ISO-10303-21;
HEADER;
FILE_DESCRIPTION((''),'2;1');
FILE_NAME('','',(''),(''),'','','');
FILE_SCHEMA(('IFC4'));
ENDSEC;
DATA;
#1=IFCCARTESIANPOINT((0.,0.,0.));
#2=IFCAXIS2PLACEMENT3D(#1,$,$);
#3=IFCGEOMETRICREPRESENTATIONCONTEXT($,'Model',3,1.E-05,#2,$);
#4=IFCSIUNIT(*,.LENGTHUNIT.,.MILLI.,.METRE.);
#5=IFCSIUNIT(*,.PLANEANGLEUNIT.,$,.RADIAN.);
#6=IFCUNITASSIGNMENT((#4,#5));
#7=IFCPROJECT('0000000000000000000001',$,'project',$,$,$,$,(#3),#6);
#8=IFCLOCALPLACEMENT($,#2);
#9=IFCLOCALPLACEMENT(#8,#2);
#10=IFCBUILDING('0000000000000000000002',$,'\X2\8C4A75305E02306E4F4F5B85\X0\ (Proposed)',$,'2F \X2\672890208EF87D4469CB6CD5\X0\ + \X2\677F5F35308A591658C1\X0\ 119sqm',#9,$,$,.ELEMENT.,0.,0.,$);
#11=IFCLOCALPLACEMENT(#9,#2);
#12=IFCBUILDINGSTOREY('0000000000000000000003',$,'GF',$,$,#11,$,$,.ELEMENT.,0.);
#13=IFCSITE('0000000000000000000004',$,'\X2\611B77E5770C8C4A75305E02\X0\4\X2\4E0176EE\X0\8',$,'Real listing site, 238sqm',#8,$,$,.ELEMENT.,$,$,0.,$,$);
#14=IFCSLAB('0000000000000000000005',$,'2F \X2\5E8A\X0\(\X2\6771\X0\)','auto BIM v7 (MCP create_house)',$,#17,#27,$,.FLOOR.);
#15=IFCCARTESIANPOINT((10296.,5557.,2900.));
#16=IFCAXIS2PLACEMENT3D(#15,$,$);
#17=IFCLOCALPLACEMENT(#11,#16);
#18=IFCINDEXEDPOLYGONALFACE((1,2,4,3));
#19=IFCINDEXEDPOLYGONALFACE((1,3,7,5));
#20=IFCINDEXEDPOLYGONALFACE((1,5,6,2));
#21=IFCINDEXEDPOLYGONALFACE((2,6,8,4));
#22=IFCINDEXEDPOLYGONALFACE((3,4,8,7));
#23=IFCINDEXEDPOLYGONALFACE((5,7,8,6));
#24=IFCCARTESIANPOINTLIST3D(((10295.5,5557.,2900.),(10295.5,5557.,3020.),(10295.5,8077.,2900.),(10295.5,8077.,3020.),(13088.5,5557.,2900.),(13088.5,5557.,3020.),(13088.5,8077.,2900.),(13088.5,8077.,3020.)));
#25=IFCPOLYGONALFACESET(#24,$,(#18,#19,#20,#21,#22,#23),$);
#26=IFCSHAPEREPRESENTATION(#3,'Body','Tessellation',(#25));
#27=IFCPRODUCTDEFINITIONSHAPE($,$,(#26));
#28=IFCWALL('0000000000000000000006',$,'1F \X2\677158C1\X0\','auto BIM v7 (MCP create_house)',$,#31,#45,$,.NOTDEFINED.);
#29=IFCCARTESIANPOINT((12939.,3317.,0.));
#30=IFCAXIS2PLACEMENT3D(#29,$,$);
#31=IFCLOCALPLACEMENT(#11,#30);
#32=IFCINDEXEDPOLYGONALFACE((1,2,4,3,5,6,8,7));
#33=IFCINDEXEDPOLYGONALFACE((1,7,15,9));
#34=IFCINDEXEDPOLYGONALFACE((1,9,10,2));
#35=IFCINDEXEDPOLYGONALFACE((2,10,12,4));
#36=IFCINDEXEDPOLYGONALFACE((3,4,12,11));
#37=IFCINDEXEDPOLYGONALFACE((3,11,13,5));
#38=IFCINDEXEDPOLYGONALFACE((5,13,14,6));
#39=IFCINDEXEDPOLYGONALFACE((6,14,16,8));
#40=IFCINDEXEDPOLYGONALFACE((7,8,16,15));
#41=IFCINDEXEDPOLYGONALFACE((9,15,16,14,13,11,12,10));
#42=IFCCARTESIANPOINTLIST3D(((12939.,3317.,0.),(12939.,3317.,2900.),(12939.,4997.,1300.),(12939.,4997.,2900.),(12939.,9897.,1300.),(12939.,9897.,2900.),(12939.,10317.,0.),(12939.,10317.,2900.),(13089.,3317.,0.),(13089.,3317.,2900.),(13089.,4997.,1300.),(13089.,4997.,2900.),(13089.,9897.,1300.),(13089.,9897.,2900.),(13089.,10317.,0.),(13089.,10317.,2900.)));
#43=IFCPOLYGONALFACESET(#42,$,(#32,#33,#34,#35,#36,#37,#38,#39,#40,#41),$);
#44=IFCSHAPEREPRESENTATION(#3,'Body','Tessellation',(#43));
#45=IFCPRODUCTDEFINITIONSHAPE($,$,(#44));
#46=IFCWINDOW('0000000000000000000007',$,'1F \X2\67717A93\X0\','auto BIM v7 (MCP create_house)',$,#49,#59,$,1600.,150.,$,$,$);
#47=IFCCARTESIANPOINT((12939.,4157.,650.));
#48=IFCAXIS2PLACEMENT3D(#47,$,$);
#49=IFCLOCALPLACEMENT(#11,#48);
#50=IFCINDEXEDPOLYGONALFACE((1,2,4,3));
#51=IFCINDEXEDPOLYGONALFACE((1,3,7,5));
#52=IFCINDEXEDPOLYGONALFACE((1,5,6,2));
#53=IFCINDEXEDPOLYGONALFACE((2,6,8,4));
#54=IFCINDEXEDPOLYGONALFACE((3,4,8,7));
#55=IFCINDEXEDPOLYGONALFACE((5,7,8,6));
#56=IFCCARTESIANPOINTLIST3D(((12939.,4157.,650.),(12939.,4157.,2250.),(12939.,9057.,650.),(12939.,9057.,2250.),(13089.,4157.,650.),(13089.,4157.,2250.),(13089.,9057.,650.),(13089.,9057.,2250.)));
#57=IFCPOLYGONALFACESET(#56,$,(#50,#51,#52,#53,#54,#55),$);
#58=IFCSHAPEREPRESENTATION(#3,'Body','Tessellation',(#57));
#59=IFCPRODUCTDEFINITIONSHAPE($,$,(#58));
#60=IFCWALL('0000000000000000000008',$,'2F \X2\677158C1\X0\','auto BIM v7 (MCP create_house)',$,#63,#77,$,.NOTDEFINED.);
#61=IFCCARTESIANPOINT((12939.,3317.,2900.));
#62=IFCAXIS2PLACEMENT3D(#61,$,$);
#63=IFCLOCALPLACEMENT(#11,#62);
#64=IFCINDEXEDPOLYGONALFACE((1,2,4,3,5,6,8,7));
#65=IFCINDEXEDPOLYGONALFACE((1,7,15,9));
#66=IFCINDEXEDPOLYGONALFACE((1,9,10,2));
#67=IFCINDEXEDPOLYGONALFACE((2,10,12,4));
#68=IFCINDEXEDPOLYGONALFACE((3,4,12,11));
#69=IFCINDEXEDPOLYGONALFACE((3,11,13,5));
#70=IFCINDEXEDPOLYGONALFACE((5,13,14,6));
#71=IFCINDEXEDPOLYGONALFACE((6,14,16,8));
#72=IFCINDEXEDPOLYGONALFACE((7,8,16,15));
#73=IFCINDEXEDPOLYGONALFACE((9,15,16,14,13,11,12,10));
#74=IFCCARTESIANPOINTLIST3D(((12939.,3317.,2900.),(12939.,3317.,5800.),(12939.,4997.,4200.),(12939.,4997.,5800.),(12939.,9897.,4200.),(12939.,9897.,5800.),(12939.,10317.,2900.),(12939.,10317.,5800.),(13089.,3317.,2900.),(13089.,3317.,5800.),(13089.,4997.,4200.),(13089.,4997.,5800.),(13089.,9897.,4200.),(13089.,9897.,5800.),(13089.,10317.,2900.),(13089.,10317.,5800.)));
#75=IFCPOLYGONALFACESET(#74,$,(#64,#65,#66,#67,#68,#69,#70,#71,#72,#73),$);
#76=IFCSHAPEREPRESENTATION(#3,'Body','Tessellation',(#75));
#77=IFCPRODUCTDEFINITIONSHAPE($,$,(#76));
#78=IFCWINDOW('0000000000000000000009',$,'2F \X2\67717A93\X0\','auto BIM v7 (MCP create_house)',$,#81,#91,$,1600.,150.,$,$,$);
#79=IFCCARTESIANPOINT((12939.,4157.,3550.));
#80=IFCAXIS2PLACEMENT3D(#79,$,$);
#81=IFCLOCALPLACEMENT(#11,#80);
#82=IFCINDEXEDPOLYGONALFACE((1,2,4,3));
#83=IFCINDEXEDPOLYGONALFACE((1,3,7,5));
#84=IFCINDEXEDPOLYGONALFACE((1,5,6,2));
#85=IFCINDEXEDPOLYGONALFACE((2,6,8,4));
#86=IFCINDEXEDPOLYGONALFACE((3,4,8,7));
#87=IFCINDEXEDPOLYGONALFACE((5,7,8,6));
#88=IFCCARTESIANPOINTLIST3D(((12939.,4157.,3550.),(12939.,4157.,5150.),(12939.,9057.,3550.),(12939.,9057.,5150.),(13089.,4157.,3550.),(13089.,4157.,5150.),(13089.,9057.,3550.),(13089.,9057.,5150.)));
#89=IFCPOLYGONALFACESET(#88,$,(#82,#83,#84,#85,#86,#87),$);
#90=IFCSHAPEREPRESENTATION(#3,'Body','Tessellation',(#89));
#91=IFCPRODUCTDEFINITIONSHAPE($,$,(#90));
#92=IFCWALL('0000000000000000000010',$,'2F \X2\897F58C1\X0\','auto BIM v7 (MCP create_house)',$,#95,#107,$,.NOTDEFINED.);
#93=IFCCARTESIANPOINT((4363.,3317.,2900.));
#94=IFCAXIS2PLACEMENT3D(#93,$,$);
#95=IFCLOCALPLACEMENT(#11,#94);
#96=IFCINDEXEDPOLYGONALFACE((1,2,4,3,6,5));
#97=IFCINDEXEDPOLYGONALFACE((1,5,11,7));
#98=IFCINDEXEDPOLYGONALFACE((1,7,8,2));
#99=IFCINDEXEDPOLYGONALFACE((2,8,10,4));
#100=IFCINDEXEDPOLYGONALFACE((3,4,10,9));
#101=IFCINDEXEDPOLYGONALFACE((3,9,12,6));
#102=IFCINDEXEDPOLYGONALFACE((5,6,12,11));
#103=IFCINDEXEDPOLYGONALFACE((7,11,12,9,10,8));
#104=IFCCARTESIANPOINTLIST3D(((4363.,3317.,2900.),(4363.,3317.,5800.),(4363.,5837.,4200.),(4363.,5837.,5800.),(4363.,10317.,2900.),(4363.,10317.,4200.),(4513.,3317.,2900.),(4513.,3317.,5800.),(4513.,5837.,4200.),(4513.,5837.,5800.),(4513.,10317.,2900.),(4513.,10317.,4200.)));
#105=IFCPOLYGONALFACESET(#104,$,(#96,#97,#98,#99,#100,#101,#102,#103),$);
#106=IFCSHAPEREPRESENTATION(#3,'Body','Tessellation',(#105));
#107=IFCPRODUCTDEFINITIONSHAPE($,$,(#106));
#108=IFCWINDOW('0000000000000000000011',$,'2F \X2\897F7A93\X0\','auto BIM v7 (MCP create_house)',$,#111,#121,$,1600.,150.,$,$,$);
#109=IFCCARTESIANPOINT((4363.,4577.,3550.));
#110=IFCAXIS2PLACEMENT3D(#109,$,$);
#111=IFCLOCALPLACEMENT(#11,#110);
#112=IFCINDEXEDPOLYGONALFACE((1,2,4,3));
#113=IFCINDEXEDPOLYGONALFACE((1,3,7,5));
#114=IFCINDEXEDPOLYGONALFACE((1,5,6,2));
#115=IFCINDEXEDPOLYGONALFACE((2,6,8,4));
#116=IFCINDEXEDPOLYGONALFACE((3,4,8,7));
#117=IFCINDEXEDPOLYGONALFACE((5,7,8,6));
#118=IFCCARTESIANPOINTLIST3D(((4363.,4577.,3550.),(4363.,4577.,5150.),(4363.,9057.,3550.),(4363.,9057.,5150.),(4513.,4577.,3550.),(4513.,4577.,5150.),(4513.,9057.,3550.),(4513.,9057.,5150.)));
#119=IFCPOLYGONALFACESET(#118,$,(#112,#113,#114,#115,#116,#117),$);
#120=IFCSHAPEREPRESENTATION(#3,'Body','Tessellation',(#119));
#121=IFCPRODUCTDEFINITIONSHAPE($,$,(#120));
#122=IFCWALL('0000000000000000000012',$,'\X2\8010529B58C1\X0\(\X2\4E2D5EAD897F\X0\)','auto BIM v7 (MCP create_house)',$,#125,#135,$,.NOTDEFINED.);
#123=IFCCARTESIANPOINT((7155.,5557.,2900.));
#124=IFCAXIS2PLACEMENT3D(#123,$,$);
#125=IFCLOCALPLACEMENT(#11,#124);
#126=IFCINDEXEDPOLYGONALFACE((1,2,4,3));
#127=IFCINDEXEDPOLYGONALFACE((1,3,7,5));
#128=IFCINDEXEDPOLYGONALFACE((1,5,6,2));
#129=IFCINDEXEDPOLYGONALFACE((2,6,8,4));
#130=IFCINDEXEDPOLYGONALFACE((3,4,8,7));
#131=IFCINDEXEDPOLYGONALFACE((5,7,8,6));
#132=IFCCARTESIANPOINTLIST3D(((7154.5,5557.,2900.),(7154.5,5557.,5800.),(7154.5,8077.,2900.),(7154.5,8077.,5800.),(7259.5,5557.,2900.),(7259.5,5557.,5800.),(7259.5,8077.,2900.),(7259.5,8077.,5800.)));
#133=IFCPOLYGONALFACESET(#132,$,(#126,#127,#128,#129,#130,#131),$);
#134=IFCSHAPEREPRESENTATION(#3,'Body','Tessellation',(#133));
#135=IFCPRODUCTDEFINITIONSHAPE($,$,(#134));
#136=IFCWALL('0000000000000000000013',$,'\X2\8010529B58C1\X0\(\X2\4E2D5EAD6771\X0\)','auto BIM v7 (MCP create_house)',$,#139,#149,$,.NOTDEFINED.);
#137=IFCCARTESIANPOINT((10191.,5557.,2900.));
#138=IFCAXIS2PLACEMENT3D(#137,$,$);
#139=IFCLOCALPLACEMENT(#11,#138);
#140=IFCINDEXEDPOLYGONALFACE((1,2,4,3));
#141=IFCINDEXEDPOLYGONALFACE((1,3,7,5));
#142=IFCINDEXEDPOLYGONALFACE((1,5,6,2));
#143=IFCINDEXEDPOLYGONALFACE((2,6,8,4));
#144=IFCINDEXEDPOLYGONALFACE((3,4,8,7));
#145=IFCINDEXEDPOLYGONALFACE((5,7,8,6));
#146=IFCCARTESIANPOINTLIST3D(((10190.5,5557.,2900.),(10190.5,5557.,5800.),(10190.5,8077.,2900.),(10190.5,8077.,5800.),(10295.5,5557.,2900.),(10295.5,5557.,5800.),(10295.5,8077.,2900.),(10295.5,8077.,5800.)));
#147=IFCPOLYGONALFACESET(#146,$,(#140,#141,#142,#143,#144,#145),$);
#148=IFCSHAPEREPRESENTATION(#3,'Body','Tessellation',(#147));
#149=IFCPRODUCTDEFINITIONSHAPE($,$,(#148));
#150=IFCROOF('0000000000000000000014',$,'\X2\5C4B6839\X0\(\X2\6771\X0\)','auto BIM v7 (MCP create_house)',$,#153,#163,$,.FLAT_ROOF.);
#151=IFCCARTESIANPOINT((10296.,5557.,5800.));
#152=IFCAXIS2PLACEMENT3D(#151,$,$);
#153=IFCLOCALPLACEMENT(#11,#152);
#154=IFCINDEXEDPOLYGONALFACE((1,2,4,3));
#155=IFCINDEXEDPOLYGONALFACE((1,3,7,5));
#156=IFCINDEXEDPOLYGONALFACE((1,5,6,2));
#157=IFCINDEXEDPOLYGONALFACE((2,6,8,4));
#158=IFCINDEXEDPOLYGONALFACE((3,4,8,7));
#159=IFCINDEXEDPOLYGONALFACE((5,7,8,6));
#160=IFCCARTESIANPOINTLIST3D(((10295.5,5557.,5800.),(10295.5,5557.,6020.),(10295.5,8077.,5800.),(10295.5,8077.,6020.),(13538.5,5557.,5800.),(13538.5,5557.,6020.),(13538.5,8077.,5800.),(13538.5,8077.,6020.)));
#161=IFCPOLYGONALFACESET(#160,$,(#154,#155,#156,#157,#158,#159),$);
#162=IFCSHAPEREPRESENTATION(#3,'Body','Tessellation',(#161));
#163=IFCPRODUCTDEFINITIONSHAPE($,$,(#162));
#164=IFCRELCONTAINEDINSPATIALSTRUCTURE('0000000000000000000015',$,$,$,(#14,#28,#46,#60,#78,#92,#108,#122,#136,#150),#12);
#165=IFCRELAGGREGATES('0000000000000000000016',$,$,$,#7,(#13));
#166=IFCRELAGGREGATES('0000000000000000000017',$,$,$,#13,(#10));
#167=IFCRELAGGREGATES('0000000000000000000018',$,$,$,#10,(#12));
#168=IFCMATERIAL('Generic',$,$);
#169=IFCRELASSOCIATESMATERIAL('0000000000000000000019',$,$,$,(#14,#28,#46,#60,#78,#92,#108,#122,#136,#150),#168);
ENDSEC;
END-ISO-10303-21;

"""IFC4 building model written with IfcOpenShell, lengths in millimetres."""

from ifc_helpers import new_model, si_unit, frame, frame_2d, origin, place, context, project, spatial, rectangle, extrude, material, element, fill, save


model = new_model("IFC4")

# Units and contexts
model_context = context("Model", 3, precision=1e-05, world=origin())
ifc_project = project(units=[si_unit("LENGTHUNIT", "METRE", prefix="MILLI"), si_unit("PLANEANGLEUNIT", "RADIAN")], contexts=[model_context])

# Site, building, storey
site_placement = place(None, origin())
site = spatial("IfcSite", under=ifc_project, at=site_placement, Name="愛知県豊田市4丁目8", ObjectType="Real listing site, 238sqm", CompositionType="ELEMENT", RefElevation=0.0)
building_placement = place(site_placement, origin())
building = spatial("IfcBuilding", under=site, at=building_placement, Name="豊田市の住宅 (Proposed)", ObjectType="2F 木造軸組構法 + 板張り外壁 119sqm", CompositionType="ELEMENT", ElevationOfRefHeight=0.0, ElevationOfTerrain=0.0)
storey_placement = place(building_placement, origin())
storey = spatial("IfcBuildingStorey", under=building, at=storey_placement, Name="GF", CompositionType="ELEMENT", Elevation=0.0)

# Slab
ifc_material = material(Name="Generic")
slab_1_placement = place(storey_placement, frame((10296.0, 5557.0, 2900.0)))
element("IfcSlab", 1, at=slab_1_placement, inside=storey, material=ifc_material, Name="2F 床(東)", Description="auto BIM v7 (MCP create_house)", PredefinedType="FLOOR", context=model_context, shape_type="SweptSolid", body=[
    extrude(rectangle(XDim=2793.0, YDim=2520.0, at=frame_2d((1396.0, 1260.0))), frame((10296.0, 5557.0, 2900.0)), (0.0, 0.0, 1.0), 120.0),
])

# Wall, opening, window
wall_1_placement = place(storey_placement, frame((12939.0, 3317.0, 0.0)))
wall_1 = element("IfcWall", 2, at=wall_1_placement, inside=storey, material=ifc_material, Name="1F 東壁", Description="auto BIM v7 (MCP create_house)", PredefinedType="NOTDEFINED", context=model_context, shape_type="SweptSolid", body=[
    extrude(rectangle(XDim=150.0, YDim=7000.0, at=frame_2d((75.0, 3500.0))), frame((12939.0, 3317.0, 0.0)), (0.0, 0.0, 1.0), 2900.0),
])
opening_1_placement = place(storey_placement, frame((12939.0, 4157.0, 650.0)))
opening_1 = element("IfcOpeningElement", 3, at=opening_1_placement, cuts=wall_1, PredefinedType="NOTDEFINED", context=model_context, shape_type="SweptSolid", body=[
    extrude(rectangle(XDim=150.0, YDim=4900.0, at=frame_2d((75.0, 2450.0))), frame((12939.0, 4157.0, 650.0)), (0.0, 0.0, 1.0), 1600.0),
])
window_1_placement = place(storey_placement, frame((12939.0, 4157.0, 650.0)))
window_1 = element("IfcWindow", 4, at=window_1_placement, inside=storey, material=ifc_material, Name="1F 東窓", Description="auto BIM v7 (MCP create_house)", OverallHeight=1600.0, OverallWidth=150.0, context=model_context, shape_type="SweptSolid", body=[
    extrude(rectangle(XDim=150.0, YDim=4900.0, at=frame_2d((75.0, 2450.0))), frame((12939.0, 4157.0, 650.0)), (0.0, 0.0, 1.0), 1600.0),
])
fill(opening_1, window_1)

# Walls, openings, windows
wall_2_placement = place(storey_placement, frame((12939.0, 3317.0, 2900.0)))
wall_2 = element("IfcWall", 5, at=wall_2_placement, inside=storey, material=ifc_material, Name="2F 東壁", Description="auto BIM v7 (MCP create_house)", PredefinedType="NOTDEFINED", context=model_context, shape_type="SweptSolid", body=[
    extrude(rectangle(XDim=150.0, YDim=7000.0, at=frame_2d((75.0, 3500.0))), frame((12939.0, 3317.0, 2900.0)), (0.0, 0.0, 1.0), 2900.0),
])
opening_2_placement = place(storey_placement, frame((12939.0, 4157.0, 3550.0)))
opening_2 = element("IfcOpeningElement", 6, at=opening_2_placement, cuts=wall_2, PredefinedType="NOTDEFINED", context=model_context, shape_type="SweptSolid", body=[
    extrude(rectangle(XDim=150.0, YDim=4900.0, at=frame_2d((75.0, 2450.0))), frame((12939.0, 4157.0, 3550.0)), (0.0, 0.0, 1.0), 1600.0),
])
window_2_placement = place(storey_placement, frame((12939.0, 4157.0, 3550.0)))
window_2 = element("IfcWindow", 7, at=window_2_placement, inside=storey, material=ifc_material, Name="2F 東窓", Description="auto BIM v7 (MCP create_house)", OverallHeight=1600.0, OverallWidth=150.0, context=model_context, shape_type="SweptSolid", body=[
    extrude(rectangle(XDim=150.0, YDim=4900.0, at=frame_2d((75.0, 2450.0))), frame((12939.0, 4157.0, 3550.0)), (0.0, 0.0, 1.0), 1600.0),
])
fill(opening_2, window_2)
wall_3_placement = place(storey_placement, frame((4363.0, 3317.0, 2900.0)))
wall_3 = element("IfcWall", 8, at=wall_3_placement, inside=storey, material=ifc_material, Name="2F 西壁", Description="auto BIM v7 (MCP create_house)", PredefinedType="NOTDEFINED", context=model_context, shape_type="SweptSolid", body=[
    extrude(rectangle(XDim=150.0, YDim=7000.0, at=frame_2d((75.0, 3500.0))), frame((4363.0, 3317.0, 2900.0)), (0.0, 0.0, 1.0), 2900.0),
])
opening_3_placement = place(storey_placement, frame((4363.0, 4577.0, 3550.0)))
opening_3 = element("IfcOpeningElement", 9, at=opening_3_placement, cuts=wall_3, PredefinedType="NOTDEFINED", context=model_context, shape_type="SweptSolid", body=[
    extrude(rectangle(XDim=150.0, YDim=4480.0, at=frame_2d((75.0, 2240.0))), frame((4363.0, 4577.0, 3550.0)), (0.0, 0.0, 1.0), 1600.0),
])
window_3_placement = place(storey_placement, frame((4363.0, 4577.0, 3550.0)))
window_3 = element("IfcWindow", 10, at=window_3_placement, inside=storey, material=ifc_material, Name="2F 西窓", Description="auto BIM v7 (MCP create_house)", OverallHeight=1600.0, OverallWidth=150.0, context=model_context, shape_type="SweptSolid", body=[
    extrude(rectangle(XDim=150.0, YDim=4480.0, at=frame_2d((75.0, 2240.0))), frame((4363.0, 4577.0, 3550.0)), (0.0, 0.0, 1.0), 1600.0),
])
fill(opening_3, window_3)

# Walls
wall_4_placement = place(storey_placement, frame((7155.0, 5557.0, 2900.0)))
element("IfcWall", 11, at=wall_4_placement, inside=storey, material=ifc_material, Name="耐力壁(中庭西)", Description="auto BIM v7 (MCP create_house)", PredefinedType="NOTDEFINED", context=model_context, shape_type="SweptSolid", body=[
    extrude(rectangle(XDim=105.0, YDim=2520.0, at=frame_2d((52.0, 1260.0))), frame((7155.0, 5557.0, 2900.0)), (0.0, 0.0, 1.0), 2900.0),
])
wall_5_placement = place(storey_placement, frame((10191.0, 5557.0, 2900.0)))
element("IfcWall", 12, at=wall_5_placement, inside=storey, material=ifc_material, Name="耐力壁(中庭東)", Description="auto BIM v7 (MCP create_house)", PredefinedType="NOTDEFINED", context=model_context, shape_type="SweptSolid", body=[
    extrude(rectangle(XDim=105.0, YDim=2520.0, at=frame_2d((52.0, 1260.0))), frame((10191.0, 5557.0, 2900.0)), (0.0, 0.0, 1.0), 2900.0),
])

# Roof
for number, where, name in (
    (13, (10296.0, 5557.0, 5800.0), "屋根(東)"),
):
    element("IfcRoof", number, at=place(storey_placement, frame(where)), inside=storey, material=ifc_material, Name=name, Description="auto BIM v7 (MCP create_house)", PredefinedType="FLAT_ROOF", context=model_context, shape_type="SweptSolid", body=[
        extrude(rectangle(XDim=3243.0, YDim=2520.0, at=frame_2d((1621.0, 1260.0))), frame((10296.0, 5557.0, 5800.0)), (0.0, 0.0, 1.0), 220.0),
    ])

save(model, "model.ifc")
